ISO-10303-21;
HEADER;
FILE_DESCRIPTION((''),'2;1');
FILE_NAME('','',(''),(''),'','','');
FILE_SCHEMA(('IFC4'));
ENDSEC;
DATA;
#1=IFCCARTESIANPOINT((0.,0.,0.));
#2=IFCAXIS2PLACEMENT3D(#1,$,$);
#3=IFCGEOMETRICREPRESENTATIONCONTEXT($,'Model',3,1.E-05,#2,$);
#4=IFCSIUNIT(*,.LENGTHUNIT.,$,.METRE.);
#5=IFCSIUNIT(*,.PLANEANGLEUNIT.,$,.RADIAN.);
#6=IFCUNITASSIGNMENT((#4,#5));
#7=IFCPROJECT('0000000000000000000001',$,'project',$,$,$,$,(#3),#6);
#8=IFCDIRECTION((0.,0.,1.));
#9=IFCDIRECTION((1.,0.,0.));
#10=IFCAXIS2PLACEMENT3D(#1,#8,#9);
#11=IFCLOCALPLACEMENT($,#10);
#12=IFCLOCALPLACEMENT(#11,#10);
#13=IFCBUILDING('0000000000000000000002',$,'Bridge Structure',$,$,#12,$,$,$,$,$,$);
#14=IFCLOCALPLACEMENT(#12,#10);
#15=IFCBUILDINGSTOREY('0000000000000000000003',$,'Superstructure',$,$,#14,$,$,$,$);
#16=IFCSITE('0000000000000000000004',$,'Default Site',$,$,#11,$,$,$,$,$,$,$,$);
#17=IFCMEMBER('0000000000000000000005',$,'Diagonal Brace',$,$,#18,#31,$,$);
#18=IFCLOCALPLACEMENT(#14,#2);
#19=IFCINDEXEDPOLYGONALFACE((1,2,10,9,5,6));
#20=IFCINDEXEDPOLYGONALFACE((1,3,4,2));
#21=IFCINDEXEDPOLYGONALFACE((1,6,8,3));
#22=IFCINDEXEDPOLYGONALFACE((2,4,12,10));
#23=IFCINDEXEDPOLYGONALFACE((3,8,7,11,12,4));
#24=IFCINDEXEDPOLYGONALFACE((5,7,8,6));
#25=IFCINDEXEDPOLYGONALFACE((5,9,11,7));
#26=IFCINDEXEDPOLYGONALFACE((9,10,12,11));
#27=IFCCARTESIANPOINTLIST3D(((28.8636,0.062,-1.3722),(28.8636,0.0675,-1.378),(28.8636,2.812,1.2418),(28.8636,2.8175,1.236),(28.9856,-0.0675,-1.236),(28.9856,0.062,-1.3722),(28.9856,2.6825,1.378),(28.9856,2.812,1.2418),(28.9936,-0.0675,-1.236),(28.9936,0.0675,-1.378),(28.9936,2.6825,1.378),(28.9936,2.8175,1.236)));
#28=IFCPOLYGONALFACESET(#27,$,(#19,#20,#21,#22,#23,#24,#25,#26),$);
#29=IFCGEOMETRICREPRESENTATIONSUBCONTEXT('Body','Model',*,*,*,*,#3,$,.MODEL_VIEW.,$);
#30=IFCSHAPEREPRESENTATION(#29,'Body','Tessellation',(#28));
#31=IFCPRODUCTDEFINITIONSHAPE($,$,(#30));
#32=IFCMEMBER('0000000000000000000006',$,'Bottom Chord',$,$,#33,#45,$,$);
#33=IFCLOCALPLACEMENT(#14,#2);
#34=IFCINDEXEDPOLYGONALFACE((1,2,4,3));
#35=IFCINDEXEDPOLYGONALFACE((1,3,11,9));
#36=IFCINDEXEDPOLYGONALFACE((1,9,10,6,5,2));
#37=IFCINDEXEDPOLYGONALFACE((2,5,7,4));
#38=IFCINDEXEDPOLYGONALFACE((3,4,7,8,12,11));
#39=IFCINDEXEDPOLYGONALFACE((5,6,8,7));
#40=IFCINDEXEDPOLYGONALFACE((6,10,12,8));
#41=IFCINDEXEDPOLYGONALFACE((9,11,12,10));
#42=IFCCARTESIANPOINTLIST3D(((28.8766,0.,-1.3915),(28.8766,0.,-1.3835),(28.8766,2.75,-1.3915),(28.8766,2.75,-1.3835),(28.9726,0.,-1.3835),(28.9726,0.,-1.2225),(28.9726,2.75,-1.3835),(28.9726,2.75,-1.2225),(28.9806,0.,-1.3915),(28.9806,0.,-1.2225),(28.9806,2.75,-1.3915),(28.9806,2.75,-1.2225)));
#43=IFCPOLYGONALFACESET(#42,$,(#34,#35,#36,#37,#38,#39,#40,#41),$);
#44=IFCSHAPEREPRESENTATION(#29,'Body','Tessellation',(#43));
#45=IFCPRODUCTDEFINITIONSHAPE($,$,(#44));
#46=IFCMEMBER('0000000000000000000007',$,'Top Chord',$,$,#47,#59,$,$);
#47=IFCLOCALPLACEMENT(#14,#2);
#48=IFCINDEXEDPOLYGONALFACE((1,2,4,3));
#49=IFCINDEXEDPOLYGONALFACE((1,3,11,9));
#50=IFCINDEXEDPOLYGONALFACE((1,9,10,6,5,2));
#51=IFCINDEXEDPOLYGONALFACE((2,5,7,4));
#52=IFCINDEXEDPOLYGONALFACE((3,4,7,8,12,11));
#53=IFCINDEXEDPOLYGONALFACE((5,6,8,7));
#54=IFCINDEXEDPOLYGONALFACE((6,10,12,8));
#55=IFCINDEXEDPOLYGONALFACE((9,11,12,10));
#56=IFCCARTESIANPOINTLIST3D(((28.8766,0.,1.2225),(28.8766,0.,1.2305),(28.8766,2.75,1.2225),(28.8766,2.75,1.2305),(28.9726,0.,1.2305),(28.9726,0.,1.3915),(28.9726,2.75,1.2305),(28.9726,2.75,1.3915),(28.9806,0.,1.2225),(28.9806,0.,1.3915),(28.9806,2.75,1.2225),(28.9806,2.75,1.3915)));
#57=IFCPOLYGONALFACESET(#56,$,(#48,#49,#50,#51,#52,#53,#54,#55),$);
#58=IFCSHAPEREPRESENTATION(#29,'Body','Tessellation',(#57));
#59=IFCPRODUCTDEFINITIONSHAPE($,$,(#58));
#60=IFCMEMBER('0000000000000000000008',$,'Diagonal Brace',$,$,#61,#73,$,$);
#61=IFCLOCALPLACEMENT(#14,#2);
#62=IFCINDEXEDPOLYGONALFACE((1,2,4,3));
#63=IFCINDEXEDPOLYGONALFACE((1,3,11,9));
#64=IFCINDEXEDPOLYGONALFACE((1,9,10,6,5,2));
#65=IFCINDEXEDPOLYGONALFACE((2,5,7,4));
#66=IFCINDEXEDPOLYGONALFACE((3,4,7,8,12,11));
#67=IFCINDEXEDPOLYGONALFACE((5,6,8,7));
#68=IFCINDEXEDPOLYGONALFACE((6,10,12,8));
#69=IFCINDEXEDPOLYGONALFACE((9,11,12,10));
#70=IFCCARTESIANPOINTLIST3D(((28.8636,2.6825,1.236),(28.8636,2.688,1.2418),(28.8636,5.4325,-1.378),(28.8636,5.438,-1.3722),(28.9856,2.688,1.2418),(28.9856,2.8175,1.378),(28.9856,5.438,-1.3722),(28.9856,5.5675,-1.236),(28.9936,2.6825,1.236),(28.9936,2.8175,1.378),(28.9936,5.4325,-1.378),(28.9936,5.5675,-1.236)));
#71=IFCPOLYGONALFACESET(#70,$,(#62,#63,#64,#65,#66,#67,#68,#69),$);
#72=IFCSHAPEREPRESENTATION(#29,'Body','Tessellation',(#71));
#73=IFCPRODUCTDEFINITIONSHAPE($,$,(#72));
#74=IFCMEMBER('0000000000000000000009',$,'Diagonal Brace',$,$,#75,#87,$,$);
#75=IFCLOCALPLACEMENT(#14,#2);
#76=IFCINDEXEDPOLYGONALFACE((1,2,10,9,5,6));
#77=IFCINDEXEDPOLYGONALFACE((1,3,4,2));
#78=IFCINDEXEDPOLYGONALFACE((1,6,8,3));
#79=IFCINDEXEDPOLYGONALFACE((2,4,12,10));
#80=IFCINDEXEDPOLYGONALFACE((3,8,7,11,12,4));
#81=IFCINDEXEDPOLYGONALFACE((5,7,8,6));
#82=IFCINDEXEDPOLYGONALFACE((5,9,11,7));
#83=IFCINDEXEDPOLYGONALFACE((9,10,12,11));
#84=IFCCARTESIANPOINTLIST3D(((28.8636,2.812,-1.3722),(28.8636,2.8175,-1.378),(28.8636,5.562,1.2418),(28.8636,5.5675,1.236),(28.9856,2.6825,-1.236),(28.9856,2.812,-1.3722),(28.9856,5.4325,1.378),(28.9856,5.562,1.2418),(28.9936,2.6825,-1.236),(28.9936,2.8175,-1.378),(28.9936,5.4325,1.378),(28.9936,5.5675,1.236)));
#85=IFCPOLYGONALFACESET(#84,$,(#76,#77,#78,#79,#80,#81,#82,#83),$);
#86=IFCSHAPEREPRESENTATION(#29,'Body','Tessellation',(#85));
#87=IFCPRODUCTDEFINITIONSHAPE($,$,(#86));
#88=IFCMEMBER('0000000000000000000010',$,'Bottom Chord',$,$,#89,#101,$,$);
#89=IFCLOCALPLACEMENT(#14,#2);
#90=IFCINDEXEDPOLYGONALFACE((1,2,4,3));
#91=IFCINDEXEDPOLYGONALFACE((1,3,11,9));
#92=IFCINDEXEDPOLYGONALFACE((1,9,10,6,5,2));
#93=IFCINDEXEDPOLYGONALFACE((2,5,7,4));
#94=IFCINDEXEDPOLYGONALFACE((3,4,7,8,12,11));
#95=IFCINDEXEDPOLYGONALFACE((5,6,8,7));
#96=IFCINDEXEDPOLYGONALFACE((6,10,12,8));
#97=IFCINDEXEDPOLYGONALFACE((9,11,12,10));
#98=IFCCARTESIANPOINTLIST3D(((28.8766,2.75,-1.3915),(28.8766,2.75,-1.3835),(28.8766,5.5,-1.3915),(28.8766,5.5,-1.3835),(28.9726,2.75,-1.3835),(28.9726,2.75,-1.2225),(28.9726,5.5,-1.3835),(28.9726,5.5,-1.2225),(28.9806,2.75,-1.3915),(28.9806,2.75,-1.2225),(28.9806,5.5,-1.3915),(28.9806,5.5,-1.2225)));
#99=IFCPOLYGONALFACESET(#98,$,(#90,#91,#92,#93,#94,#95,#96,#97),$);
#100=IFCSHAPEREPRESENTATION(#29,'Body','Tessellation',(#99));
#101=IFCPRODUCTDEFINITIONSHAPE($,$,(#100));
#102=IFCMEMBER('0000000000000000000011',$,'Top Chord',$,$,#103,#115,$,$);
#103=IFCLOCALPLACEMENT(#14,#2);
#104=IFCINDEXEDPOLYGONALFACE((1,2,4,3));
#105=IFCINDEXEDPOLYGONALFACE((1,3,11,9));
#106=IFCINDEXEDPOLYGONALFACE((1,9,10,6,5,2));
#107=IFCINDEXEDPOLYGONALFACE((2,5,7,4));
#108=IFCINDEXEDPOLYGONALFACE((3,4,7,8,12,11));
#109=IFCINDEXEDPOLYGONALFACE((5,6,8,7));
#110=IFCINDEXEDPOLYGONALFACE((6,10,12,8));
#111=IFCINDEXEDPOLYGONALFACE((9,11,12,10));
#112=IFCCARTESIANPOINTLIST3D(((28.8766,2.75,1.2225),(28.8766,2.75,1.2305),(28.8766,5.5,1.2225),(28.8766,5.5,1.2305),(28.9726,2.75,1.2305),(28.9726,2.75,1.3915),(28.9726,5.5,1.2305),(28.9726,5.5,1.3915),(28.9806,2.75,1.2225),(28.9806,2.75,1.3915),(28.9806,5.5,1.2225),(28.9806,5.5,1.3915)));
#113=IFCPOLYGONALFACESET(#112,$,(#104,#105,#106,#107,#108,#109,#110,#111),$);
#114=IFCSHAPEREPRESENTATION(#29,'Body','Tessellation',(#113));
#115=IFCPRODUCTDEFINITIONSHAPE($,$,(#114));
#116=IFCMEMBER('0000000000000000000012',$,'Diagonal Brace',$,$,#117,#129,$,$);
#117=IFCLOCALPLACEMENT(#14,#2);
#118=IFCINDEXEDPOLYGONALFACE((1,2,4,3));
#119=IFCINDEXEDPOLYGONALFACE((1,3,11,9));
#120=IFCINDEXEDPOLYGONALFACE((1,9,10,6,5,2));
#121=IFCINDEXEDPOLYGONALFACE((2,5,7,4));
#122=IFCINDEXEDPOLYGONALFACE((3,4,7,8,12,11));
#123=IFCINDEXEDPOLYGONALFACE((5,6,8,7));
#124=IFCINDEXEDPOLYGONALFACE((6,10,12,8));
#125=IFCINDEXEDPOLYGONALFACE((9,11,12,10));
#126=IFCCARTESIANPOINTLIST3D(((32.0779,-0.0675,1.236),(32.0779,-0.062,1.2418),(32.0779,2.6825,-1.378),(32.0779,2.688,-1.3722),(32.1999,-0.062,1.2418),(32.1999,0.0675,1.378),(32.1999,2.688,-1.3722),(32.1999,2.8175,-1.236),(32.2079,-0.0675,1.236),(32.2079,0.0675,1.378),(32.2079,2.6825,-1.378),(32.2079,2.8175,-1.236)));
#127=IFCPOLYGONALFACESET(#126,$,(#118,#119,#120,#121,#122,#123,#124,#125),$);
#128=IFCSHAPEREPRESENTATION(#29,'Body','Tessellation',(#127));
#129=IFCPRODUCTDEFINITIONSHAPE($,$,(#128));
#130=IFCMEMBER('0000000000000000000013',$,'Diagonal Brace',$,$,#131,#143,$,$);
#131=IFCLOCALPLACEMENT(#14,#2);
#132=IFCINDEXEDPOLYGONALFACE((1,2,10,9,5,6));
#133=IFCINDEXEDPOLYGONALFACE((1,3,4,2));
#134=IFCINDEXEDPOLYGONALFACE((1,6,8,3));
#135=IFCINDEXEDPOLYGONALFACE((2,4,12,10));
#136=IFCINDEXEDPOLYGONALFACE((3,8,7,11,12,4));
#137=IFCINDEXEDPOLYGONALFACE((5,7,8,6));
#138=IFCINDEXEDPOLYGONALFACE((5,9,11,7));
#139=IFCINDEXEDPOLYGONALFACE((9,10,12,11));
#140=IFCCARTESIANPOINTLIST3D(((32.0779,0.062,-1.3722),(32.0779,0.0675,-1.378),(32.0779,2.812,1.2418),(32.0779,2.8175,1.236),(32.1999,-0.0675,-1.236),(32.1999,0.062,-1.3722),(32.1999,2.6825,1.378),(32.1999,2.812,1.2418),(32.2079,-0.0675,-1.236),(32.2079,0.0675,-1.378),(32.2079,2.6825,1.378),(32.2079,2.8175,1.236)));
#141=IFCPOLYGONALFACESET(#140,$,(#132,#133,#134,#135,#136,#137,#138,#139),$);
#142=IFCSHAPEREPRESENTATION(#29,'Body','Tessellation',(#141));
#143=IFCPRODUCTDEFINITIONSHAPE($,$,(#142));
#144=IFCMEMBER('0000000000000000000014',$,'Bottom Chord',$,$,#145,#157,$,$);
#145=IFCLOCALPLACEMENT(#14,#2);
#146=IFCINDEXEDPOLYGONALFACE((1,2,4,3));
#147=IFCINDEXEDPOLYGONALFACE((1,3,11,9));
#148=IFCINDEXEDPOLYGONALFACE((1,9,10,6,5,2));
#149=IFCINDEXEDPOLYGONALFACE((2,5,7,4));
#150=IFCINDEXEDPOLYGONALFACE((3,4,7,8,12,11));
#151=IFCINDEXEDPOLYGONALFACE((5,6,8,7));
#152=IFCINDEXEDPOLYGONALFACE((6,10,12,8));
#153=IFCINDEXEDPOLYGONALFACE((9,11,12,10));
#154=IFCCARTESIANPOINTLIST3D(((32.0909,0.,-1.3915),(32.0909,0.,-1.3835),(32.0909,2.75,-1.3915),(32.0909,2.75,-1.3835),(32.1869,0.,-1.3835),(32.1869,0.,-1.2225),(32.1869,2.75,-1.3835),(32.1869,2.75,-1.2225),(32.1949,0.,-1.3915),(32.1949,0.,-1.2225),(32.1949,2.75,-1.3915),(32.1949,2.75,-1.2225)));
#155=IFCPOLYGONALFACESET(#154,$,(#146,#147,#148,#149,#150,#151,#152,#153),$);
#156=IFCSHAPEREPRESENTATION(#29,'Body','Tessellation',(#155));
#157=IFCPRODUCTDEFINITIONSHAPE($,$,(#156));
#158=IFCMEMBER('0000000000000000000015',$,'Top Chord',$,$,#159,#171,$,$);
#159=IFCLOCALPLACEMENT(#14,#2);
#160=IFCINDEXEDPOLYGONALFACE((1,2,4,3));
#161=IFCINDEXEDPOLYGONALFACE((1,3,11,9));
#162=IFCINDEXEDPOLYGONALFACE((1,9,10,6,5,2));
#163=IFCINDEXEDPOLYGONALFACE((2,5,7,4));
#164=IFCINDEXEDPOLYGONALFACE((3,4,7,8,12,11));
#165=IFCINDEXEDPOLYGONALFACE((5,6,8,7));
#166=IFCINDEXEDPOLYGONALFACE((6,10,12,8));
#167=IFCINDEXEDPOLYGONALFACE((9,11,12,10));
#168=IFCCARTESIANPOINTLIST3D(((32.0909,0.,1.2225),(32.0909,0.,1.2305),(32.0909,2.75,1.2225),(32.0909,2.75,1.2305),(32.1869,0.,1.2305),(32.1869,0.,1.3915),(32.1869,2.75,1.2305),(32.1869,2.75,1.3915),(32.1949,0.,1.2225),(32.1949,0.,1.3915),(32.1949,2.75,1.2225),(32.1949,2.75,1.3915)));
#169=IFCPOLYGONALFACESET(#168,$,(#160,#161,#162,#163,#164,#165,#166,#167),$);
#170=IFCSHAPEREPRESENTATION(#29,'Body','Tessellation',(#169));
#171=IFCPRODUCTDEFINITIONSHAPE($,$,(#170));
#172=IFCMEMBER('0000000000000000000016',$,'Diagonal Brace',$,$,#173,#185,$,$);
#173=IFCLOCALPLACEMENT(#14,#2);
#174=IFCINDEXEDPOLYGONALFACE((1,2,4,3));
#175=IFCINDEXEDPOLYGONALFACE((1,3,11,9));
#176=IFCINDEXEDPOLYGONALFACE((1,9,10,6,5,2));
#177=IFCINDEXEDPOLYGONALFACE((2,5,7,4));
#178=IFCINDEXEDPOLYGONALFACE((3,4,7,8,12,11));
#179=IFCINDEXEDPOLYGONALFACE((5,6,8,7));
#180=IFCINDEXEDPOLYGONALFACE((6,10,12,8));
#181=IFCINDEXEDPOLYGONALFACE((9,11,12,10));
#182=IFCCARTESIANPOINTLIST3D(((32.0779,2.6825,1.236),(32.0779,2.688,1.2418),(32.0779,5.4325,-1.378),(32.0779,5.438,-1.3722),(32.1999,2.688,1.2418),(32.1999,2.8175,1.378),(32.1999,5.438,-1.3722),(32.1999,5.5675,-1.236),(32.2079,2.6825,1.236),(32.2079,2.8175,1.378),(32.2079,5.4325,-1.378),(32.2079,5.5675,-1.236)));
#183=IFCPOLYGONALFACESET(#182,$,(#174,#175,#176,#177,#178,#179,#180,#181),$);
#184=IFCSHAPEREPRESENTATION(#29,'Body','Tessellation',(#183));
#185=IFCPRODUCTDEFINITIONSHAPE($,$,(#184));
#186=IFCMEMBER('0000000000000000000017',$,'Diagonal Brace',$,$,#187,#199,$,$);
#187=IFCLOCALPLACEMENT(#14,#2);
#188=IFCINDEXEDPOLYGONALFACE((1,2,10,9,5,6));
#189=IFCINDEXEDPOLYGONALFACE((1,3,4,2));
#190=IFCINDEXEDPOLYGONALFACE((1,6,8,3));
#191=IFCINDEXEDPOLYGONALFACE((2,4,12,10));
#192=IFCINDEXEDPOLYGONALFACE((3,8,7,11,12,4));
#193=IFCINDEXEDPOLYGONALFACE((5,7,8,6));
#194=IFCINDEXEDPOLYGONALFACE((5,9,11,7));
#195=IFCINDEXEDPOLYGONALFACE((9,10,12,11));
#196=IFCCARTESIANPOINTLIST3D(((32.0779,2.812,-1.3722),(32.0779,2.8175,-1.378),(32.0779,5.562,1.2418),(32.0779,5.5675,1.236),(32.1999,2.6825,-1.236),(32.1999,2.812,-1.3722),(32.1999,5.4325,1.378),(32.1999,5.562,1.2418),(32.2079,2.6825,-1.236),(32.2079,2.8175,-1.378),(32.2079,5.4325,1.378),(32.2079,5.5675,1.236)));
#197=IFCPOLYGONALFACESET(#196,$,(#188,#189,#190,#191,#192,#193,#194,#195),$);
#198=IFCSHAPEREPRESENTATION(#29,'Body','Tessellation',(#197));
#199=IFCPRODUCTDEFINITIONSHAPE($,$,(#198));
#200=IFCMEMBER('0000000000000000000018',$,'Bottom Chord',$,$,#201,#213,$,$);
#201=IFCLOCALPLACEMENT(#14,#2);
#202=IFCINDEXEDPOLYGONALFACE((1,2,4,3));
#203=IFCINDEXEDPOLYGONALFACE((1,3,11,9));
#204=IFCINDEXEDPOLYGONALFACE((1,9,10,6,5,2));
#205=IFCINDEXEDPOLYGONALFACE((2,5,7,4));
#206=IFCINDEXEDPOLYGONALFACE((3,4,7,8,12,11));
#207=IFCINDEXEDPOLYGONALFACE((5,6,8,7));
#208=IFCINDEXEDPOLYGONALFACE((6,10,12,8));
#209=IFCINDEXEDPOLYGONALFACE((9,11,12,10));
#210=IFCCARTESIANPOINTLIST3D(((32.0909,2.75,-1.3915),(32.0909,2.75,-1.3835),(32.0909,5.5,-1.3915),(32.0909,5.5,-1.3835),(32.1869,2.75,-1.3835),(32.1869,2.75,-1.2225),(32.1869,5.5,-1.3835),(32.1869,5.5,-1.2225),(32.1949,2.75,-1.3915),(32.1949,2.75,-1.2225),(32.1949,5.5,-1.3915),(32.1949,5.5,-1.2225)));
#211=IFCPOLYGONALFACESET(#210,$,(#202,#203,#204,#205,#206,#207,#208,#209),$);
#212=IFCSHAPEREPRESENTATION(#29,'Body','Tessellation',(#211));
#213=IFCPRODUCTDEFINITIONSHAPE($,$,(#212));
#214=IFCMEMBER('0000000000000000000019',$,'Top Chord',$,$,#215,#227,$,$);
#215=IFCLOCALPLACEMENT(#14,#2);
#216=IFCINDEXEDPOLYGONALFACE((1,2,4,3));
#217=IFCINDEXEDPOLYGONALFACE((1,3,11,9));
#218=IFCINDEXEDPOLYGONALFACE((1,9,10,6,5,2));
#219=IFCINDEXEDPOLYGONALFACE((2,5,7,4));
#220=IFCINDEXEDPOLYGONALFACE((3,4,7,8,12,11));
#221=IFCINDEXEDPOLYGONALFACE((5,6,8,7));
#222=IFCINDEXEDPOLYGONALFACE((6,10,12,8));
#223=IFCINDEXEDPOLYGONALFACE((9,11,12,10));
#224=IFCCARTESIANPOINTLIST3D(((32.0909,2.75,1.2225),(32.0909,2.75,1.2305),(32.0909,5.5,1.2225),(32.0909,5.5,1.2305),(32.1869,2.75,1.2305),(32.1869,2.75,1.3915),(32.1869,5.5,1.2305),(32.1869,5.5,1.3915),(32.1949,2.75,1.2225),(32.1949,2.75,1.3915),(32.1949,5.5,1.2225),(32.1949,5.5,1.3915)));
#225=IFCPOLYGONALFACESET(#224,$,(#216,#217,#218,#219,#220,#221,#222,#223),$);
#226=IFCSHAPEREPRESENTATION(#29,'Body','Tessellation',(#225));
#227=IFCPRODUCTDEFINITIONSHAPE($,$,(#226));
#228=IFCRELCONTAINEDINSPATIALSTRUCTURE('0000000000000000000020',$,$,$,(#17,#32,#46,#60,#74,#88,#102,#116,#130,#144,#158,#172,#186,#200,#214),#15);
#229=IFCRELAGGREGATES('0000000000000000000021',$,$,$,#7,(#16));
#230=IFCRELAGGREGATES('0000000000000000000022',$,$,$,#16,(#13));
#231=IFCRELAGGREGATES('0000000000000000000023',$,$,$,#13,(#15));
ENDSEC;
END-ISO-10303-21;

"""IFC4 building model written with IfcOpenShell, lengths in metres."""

from ifc_helpers import new_model, si_unit, frame, origin, origin_with_axes, origin_2d_with_axis, place, context, subcontext, project, spatial, l_section, extrude, element, save


model = new_model("IFC4")

# Units and contexts
model_context = context("Model", 3, precision=1e-05, world=origin())
body_context = subcontext(model_context, "Body", "Model", "MODEL_VIEW")
ifc_project = project(units=[si_unit("LENGTHUNIT", "METRE"), si_unit("PLANEANGLEUNIT", "RADIAN")], contexts=[model_context])

# Site, building, storey
site_placement = place(None, origin_with_axes())
site = spatial("IfcSite", under=ifc_project, at=site_placement, Name="Default Site")
building_placement = place(site_placement, origin_with_axes())
building = spatial("IfcBuilding", under=site, at=building_placement, Name="Bridge Structure")
storey_placement = place(building_placement, origin_with_axes())
storey = spatial("IfcBuildingStorey", under=building, at=storey_placement, Name="Superstructure")

# Members
member_placement = place(storey_placement, frame((28.9286, 0.0, -1.307), z_axis=(0.0, 0.724802, 0.688957), x_axis=(-1.0, 0.0, 0.0)))
element("IfcMember", 1, at=member_placement, inside=storey, Name="Diagonal Brace", context=body_context, shape_type="SweptSolid", body=[
    extrude(l_section(Depth=0.196, Width=0.13, Thickness=0.008, at=origin_2d_with_axis()), origin_with_axes(), (0.0, 0.0, 1.0), 3.7941),
])
for number, where, z_axis, x_axis, name in (
    (2, (28.9286, 0.0, -1.307), (0.0, 1.0, 0.0), (-1.0, 0.0, 0.0), "Bottom Chord"),
    (3, (28.9286, 0.0, 1.307), (0.0, 1.0, 0.0), (-1.0, 0.0, 0.0), "Top Chord"),
):
    element("IfcMember", number, at=place(storey_placement, frame(where, z_axis=z_axis, x_axis=x_axis)), inside=storey, Name=name, context=body_context, shape_type="SweptSolid", body=[
        extrude(l_section(Depth=0.169, Width=0.104, Thickness=0.008, at=origin_2d_with_axis()), origin_with_axes(), (0.0, 0.0, 1.0), 2.75),
    ])
for number, where, z_axis, x_axis, name in (
    (4, (28.9286, 2.75, 1.307), (0.0, 0.724802, -0.688957), (-1.0, 0.0, 0.0), "Diagonal Brace"),
    (5, (28.9286, 2.75, -1.307), (0.0, 0.724802, 0.688957), (-1.0, 0.0, 0.0), "Diagonal Brace"),
):
    element("IfcMember", number, at=place(storey_placement, frame(where, z_axis=z_axis, x_axis=x_axis)), inside=storey, Name=name, context=body_context, shape_type="SweptSolid", body=[
        extrude(l_section(Depth=0.196, Width=0.13, Thickness=0.008, at=origin_2d_with_axis()), origin_with_axes(), (0.0, 0.0, 1.0), 3.7941),
    ])
for number, where, z_axis, x_axis, name in (
    (6, (28.9286, 2.75, -1.307), (0.0, 1.0, 0.0), (-1.0, 0.0, 0.0), "Bottom Chord"),
    (7, (28.9286, 2.75, 1.307), (0.0, 1.0, 0.0), (-1.0, 0.0, 0.0), "Top Chord"),
):
    element("IfcMember", number, at=place(storey_placement, frame(where, z_axis=z_axis, x_axis=x_axis)), inside=storey, Name=name, context=body_context, shape_type="SweptSolid", body=[
        extrude(l_section(Depth=0.169, Width=0.104, Thickness=0.008, at=origin_2d_with_axis()), origin_with_axes(), (0.0, 0.0, 1.0), 2.75),
    ])
for number, where, z_axis, x_axis, name in (
    (8, (32.1429, 0.0, 1.307), (0.0, 0.724802, -0.688957), (-1.0, 0.0, 0.0), "Diagonal Brace"),
    (9, (32.1429, 0.0, -1.307), (0.0, 0.724802, 0.688957), (-1.0, 0.0, 0.0), "Diagonal Brace"),
):
    element("IfcMember", number, at=place(storey_placement, frame(where, z_axis=z_axis, x_axis=x_axis)), inside=storey, Name=name, context=body_context, shape_type="SweptSolid", body=[
        extrude(l_section(Depth=0.196, Width=0.13, Thickness=0.008, at=origin_2d_with_axis()), origin_with_axes(), (0.0, 0.0, 1.0), 3.7941),
    ])
for number, where, z_axis, x_axis, name in (
    (10, (32.1429, 0.0, -1.307), (0.0, 1.0, 0.0), (-1.0, 0.0, 0.0), "Bottom Chord"),
    (11, (32.1429, 0.0, 1.307), (0.0, 1.0, 0.0), (-1.0, 0.0, 0.0), "Top Chord"),
):
    element("IfcMember", number, at=place(storey_placement, frame(where, z_axis=z_axis, x_axis=x_axis)), inside=storey, Name=name, context=body_context, shape_type="SweptSolid", body=[
        extrude(l_section(Depth=0.169, Width=0.104, Thickness=0.008, at=origin_2d_with_axis()), origin_with_axes(), (0.0, 0.0, 1.0), 2.75),
    ])
for number, where, z_axis, x_axis, name in (
    (12, (32.1429, 2.75, 1.307), (0.0, 0.724802, -0.688957), (-1.0, 0.0, 0.0), "Diagonal Brace"),
    (13, (32.1429, 2.75, -1.307), (0.0, 0.724802, 0.688957), (-1.0, 0.0, 0.0), "Diagonal Brace"),
):
    element("IfcMember", number, at=place(storey_placement, frame(where, z_axis=z_axis, x_axis=x_axis)), inside=storey, Name=name, context=body_context, shape_type="SweptSolid", body=[
        extrude(l_section(Depth=0.196, Width=0.13, Thickness=0.008, at=origin_2d_with_axis()), origin_with_axes(), (0.0, 0.0, 1.0), 3.7941),
    ])
for number, where, z_axis, x_axis, name in (
    (14, (32.1429, 2.75, -1.307), (0.0, 1.0, 0.0), (-1.0, 0.0, 0.0), "Bottom Chord"),
    (15, (32.1429, 2.75, 1.307), (0.0, 1.0, 0.0), (-1.0, 0.0, 0.0), "Top Chord"),
):
    element("IfcMember", number, at=place(storey_placement, frame(where, z_axis=z_axis, x_axis=x_axis)), inside=storey, Name=name, context=body_context, shape_type="SweptSolid", body=[
        extrude(l_section(Depth=0.169, Width=0.104, Thickness=0.008, at=origin_2d_with_axis()), origin_with_axes(), (0.0, 0.0, 1.0), 2.75),
    ])

save(model, "model.ifc")
